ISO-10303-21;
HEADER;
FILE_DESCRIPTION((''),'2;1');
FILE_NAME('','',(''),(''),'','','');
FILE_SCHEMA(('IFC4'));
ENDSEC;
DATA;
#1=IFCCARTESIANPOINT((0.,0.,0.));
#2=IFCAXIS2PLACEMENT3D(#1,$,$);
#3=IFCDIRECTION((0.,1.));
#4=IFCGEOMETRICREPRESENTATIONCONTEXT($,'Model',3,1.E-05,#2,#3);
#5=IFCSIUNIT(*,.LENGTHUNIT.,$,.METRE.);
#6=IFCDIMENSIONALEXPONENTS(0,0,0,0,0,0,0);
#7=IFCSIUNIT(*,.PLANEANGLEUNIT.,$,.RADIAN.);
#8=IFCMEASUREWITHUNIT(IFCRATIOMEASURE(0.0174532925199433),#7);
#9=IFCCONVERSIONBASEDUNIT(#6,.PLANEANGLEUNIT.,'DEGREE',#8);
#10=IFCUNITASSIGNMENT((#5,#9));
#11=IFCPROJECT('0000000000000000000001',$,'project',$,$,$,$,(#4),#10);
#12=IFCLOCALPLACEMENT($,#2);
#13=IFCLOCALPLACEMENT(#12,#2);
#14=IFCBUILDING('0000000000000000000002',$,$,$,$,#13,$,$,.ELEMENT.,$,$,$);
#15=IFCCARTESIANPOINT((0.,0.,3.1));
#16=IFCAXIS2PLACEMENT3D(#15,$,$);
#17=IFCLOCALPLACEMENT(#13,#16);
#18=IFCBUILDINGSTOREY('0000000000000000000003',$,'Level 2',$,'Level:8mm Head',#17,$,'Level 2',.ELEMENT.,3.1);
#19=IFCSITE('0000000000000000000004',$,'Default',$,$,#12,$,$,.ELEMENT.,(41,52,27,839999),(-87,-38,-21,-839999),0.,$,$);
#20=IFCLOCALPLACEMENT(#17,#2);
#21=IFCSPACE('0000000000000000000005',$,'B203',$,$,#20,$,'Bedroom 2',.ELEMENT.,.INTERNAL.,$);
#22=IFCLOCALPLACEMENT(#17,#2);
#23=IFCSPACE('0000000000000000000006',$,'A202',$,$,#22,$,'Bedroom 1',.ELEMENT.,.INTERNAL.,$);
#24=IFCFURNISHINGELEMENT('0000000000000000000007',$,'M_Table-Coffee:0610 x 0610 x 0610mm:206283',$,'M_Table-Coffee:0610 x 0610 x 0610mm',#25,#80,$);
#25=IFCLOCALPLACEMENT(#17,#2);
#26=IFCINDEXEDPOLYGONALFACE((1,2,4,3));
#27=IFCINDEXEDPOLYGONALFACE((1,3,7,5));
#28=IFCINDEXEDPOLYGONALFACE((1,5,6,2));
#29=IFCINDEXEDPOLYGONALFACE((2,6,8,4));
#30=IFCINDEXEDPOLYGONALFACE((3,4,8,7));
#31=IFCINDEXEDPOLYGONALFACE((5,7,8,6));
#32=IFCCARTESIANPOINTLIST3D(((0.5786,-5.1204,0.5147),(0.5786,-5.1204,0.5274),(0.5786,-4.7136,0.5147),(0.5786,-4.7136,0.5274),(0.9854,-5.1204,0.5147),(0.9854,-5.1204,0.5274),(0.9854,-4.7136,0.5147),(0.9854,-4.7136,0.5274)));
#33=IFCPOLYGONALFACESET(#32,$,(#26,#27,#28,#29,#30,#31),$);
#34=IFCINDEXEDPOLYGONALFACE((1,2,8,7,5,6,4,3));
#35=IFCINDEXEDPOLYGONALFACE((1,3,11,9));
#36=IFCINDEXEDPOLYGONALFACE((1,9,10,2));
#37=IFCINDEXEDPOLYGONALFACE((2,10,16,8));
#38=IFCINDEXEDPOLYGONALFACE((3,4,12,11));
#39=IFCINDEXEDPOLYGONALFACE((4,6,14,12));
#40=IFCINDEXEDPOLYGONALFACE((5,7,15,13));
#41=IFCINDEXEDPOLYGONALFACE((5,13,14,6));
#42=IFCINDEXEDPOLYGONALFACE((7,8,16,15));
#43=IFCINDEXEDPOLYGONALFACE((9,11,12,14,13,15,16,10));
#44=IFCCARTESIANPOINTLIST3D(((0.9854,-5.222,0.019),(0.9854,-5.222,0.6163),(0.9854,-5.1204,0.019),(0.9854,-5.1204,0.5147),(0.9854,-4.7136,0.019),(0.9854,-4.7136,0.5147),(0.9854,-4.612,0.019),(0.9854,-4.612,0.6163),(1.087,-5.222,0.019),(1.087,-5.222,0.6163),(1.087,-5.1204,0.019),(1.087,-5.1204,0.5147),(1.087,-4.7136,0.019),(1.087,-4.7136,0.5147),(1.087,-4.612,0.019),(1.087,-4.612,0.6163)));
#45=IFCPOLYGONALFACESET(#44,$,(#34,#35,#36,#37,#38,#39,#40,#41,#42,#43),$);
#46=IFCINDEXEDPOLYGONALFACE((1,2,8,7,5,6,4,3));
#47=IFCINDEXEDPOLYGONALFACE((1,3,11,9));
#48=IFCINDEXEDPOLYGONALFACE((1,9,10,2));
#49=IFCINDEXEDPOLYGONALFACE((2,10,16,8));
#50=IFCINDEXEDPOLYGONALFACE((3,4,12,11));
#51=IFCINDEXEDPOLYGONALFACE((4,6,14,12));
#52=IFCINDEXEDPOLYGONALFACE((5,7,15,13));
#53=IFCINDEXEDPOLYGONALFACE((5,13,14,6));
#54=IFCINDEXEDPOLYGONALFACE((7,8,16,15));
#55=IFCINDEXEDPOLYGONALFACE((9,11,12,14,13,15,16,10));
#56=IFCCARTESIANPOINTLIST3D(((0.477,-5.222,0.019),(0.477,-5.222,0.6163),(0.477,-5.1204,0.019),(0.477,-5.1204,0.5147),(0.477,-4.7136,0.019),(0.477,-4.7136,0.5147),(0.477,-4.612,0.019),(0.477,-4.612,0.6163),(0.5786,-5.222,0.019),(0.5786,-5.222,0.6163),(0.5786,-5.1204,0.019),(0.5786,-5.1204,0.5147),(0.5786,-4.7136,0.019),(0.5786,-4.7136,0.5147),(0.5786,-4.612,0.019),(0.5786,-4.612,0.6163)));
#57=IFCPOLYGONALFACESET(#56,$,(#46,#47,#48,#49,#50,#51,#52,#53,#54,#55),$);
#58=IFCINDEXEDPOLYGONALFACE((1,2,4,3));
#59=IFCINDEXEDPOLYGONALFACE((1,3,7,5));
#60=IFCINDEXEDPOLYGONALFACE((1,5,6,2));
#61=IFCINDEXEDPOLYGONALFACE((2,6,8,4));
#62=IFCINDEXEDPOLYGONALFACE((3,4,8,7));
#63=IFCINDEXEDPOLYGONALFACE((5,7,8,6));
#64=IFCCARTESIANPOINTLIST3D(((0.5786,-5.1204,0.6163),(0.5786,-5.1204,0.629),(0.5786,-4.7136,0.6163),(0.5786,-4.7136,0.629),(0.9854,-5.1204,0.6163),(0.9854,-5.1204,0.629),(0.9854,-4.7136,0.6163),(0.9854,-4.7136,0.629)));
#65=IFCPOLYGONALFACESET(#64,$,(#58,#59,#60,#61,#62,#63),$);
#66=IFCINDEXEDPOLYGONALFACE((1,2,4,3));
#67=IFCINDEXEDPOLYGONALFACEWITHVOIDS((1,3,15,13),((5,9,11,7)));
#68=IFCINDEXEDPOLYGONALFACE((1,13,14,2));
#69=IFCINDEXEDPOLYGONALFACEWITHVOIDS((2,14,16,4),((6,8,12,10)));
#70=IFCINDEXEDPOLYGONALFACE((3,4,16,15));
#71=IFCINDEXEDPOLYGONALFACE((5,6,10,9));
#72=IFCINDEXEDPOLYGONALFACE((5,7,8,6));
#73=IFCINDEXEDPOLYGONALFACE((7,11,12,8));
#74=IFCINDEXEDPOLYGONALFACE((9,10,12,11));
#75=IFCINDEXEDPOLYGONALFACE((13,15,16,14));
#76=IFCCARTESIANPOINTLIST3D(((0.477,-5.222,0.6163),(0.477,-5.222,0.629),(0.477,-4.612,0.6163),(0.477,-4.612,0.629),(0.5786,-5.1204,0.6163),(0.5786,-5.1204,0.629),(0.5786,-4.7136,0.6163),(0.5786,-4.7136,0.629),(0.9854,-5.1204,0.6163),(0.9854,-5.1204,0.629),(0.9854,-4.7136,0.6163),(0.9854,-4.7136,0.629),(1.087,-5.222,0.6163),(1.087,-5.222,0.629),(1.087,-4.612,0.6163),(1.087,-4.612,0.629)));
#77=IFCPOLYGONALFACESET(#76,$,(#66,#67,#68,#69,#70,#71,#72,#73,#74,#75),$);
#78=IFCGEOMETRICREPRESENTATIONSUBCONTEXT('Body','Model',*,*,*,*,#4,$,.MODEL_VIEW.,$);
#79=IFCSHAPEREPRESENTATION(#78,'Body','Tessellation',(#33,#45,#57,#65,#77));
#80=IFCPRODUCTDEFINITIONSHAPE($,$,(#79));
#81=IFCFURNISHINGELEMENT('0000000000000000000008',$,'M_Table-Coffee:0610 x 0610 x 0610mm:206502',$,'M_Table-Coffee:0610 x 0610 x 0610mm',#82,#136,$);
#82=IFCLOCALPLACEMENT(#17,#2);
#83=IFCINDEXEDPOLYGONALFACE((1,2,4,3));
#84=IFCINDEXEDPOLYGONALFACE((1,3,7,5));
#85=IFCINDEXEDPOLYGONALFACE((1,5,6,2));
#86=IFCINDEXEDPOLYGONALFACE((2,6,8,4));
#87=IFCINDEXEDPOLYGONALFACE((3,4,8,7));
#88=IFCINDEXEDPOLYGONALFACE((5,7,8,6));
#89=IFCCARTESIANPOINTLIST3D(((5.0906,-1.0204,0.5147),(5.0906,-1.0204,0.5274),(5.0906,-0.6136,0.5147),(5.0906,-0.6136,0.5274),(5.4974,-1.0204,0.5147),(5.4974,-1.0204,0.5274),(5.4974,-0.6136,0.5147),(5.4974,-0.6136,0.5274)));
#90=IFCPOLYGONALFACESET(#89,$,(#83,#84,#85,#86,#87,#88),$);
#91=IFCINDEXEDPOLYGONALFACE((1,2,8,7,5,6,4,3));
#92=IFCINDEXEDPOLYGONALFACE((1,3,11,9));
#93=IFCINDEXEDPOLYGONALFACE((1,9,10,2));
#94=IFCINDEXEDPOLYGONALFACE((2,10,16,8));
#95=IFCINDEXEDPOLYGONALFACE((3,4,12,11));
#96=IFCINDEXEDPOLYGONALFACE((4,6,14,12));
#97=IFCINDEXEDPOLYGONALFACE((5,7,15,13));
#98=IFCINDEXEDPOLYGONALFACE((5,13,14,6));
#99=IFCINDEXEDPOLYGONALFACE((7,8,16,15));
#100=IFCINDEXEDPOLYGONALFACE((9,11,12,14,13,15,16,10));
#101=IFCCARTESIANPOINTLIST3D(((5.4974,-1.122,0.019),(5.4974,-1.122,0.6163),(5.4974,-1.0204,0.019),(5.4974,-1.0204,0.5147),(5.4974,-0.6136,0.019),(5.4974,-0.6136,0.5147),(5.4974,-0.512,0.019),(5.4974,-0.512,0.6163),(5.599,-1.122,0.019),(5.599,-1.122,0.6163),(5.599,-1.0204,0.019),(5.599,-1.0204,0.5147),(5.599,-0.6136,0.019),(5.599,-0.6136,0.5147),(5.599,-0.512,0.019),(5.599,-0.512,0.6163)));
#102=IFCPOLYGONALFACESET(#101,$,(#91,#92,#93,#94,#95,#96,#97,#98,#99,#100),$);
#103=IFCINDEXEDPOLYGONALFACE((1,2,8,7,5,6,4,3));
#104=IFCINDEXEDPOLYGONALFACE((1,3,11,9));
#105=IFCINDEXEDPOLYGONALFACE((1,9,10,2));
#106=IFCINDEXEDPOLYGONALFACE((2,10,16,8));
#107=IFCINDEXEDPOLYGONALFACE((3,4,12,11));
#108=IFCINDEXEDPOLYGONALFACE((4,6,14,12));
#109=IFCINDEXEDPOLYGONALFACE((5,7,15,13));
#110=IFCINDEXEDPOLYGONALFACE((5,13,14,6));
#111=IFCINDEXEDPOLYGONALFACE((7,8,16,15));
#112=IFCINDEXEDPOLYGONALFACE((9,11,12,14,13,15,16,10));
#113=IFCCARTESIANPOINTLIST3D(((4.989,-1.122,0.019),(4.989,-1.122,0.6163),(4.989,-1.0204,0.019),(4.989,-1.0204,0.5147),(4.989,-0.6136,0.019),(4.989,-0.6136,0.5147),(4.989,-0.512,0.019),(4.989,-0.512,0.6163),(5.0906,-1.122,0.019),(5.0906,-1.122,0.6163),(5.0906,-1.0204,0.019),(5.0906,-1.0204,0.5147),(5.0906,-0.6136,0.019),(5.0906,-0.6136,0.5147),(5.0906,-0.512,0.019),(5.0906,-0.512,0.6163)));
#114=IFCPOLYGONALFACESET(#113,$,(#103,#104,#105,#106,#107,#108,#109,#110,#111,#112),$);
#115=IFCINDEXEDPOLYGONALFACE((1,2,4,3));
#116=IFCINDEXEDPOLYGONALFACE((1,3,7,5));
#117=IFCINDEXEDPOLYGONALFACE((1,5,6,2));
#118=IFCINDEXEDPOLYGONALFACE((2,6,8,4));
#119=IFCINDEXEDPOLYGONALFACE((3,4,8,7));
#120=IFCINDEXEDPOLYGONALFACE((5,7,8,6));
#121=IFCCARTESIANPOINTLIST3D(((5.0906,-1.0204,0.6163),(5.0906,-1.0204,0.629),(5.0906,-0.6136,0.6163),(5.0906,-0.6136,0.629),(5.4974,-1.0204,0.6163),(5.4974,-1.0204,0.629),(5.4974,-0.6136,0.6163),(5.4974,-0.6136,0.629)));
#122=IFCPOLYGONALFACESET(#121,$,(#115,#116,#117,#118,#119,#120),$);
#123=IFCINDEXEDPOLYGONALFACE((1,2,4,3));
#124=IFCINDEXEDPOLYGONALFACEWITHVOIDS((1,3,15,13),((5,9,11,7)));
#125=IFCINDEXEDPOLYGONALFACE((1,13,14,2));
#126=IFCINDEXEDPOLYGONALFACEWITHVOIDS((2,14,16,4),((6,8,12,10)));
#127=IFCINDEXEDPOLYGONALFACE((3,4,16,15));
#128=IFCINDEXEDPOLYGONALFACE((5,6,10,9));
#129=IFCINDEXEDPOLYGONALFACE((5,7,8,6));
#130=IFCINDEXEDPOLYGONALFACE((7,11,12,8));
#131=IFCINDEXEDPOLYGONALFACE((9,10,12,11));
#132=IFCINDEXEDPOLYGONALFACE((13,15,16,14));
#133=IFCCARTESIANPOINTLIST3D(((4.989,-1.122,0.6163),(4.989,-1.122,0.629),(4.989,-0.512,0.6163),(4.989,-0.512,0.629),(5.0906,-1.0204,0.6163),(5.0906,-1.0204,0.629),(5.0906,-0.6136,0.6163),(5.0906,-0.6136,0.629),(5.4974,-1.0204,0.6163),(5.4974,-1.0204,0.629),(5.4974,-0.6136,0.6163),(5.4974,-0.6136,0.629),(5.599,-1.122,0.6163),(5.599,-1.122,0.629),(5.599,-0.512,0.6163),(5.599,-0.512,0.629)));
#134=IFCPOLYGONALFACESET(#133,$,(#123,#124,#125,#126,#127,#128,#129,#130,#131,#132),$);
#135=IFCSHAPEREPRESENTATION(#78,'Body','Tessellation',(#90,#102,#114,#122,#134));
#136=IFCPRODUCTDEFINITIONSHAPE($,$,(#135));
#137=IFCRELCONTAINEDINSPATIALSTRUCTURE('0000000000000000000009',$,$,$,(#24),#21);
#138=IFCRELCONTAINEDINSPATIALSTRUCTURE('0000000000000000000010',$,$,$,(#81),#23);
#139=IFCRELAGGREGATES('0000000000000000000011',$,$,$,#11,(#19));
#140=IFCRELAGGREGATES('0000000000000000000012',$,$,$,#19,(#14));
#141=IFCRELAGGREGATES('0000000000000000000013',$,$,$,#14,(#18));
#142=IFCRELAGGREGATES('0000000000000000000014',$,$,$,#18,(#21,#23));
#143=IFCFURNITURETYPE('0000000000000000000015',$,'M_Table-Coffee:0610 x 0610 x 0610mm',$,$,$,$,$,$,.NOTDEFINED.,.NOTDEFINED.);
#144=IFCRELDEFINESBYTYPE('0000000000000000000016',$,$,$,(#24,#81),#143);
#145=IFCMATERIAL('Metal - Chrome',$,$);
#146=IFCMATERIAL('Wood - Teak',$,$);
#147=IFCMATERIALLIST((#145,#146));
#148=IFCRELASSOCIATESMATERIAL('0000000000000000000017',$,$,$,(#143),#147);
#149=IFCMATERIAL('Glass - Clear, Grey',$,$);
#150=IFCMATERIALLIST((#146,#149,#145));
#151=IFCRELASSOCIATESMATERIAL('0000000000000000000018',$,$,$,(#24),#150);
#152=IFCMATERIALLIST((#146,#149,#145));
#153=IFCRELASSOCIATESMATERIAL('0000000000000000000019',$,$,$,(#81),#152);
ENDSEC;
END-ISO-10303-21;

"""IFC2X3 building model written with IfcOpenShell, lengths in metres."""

from ifc_helpers import new_model, entity, si_unit, converted_unit, direction, frame, origin, origin_2d_with_axis, place, context, subcontext, project, spatial, polyline, rectangle, outline, extrude, source, transform, mapped, material, material_list, type_object, type_shapes, element, save


model = new_model("IFC2X3")

# Units and contexts
model_context = context("Model", 3, precision=1e-05, world=origin(), true_north=direction((0.0, 1.0)))
body_context = subcontext(model_context, "Body", "Model", "MODEL_VIEW")
ifc_project = project(units=[si_unit("LENGTHUNIT", "METRE"), converted_unit("PLANEANGLEUNIT", "DEGREE", entity("IfcRatioMeasure", 0.0174532925199433), si_unit("PLANEANGLEUNIT", "RADIAN"), dimensions=[0, 0, 0, 0, 0, 0, 0])], contexts=[model_context])

# Site, building, storey
site_placement = place(None, origin())
site = spatial("IfcSite", under=ifc_project, at=site_placement, Name="Default", CompositionType="ELEMENT", RefLatitude=(41, 52, 27, 839999), RefLongitude=(-87, -38, -21, -839999), RefElevation=0.0)
building_placement = place(site_placement, origin())
building = spatial("IfcBuilding", under=site, at=building_placement, CompositionType="ELEMENT")
storey_placement = place(building_placement, frame((0.0, 0.0, 3.1)))
storey = spatial("IfcBuildingStorey", under=building, at=storey_placement, Name="Level 2", ObjectType="Level:8mm Head", LongName="Level 2", CompositionType="ELEMENT", Elevation=3.1)

# Shared definitions
space_1_placement = place(storey_placement, origin())
space_1 = spatial("IfcSpace", under=storey, at=space_1_placement, Name="B203", LongName="Bedroom 2", CompositionType="ELEMENT", InteriorOrExteriorSpace="INTERNAL")

# Furnishing element
ifc_material_1 = material(Name="Wood - Teak")
ifc_material_2 = material(Name="Glass - Clear, Grey")
ifc_material_3 = material(Name="Metal - Chrome")
ifc_material_list_1 = material_list([ifc_material_1, ifc_material_2, ifc_material_3])
ifc_material_list_2 = material_list([ifc_material_3, ifc_material_1])
furniture_type_1 = type_object("IfcFurnitureType", Name="M_Table-Coffee:0610 x 0610 x 0610mm", material=ifc_material_list_2)
shared_shape_1 = source(origin(), body_context, "Body", "SweptSolid", [
    extrude(rectangle(XDim=0.4068, YDim=0.4068, at=origin_2d_with_axis()), frame((0.0183, 0.0952, 0.4957), z_axis=(0.0, 0.0, 1.0), x_axis=(-1.0, 0.0, 0.0)), (0.0, 0.0, 1.0), 0.0127),
    extrude(outline(polyline([(-0.2732, -0.305), (0.324, -0.305), (0.324, 0.305), (-0.2732, 0.305), (-0.2732, 0.2034), (0.2225, 0.2034), (0.2225, -0.2034), (-0.2732, -0.2034), (-0.2732, -0.305)])), frame((0.2217, 0.0952, 0.2732), z_axis=(1.0, 0.0, 0.0), x_axis=(0.0, 0.0, 1.0)), (0.0, 0.0, 1.0), 0.1016),
    extrude(outline(polyline([(-0.305, -0.3241), (0.305, -0.3241), (0.305, 0.2733), (0.2034, 0.2733), (0.2034, -0.2224), (-0.2034, -0.2224), (-0.2034, 0.2733), (-0.305, 0.2733), (-0.305, -0.3241)])), frame((-0.2867, 0.0952, 0.2733), z_axis=(1.0, 0.0, 0.0), x_axis=(0.0, -1.0, 0.0)), (0.0, 0.0, 1.0), 0.1016),
    extrude(rectangle(XDim=0.4068, YDim=0.4068, at=origin_2d_with_axis()), frame((0.0183, 0.0952, 0.5973), z_axis=(0.0, 0.0, 1.0), x_axis=(-1.0, 0.0, 0.0)), (0.0, 0.0, 1.0), 0.0127),
    extrude(outline(polyline([(-0.305, -0.305), (0.305, -0.305), (0.305, 0.305), (-0.305, 0.305), (-0.305, -0.305)]), holes=[polyline([(-0.2034, -0.2034), (-0.2034, 0.2034), (0.2034, 0.2034), (0.2034, -0.2034), (-0.2034, -0.2034)])]), frame((0.0183, 0.0952, 0.5973), z_axis=(0.0, 0.0, 1.0), x_axis=(-1.0, 0.0, 0.0)), (0.0, 0.0, 1.0), 0.0127),
])
type_shapes(furniture_type_1, [shared_shape_1])
furnishing_1_placement = place(space_1_placement, frame((0.7637, -5.0122, 0.019)))
element("IfcFurnishingElement", 1, at=furnishing_1_placement, inside=space_1, type_object=furniture_type_1, material=ifc_material_list_1, Name="M_Table-Coffee:0610 x 0610 x 0610mm:206283", ObjectType="M_Table-Coffee:0610 x 0610 x 0610mm", context=body_context, shape_type="MappedRepresentation", body=[
    mapped(shared_shape_1, transform((0.0, 0.0, 0.0), scale=1.0)),
])

# Shared definitions
space_2_placement = place(storey_placement, origin())
space_2 = spatial("IfcSpace", under=storey, at=space_2_placement, Name="A202", LongName="Bedroom 1", CompositionType="ELEMENT", InteriorOrExteriorSpace="INTERNAL")

# Furnishing element
ifc_material_list_3 = material_list([ifc_material_1, ifc_material_2, ifc_material_3])
furnishing_2_placement = place(space_2_placement, frame((5.2757, -0.9122, 0.019)))
element("IfcFurnishingElement", 2, at=furnishing_2_placement, inside=space_2, type_object=furniture_type_1, material=ifc_material_list_3, Name="M_Table-Coffee:0610 x 0610 x 0610mm:206502", ObjectType="M_Table-Coffee:0610 x 0610 x 0610mm", context=body_context, shape_type="MappedRepresentation", body=[
    mapped(shared_shape_1, transform((0.0, 0.0, 0.0), scale=1.0)),
])

save(model, "model.ifc")
